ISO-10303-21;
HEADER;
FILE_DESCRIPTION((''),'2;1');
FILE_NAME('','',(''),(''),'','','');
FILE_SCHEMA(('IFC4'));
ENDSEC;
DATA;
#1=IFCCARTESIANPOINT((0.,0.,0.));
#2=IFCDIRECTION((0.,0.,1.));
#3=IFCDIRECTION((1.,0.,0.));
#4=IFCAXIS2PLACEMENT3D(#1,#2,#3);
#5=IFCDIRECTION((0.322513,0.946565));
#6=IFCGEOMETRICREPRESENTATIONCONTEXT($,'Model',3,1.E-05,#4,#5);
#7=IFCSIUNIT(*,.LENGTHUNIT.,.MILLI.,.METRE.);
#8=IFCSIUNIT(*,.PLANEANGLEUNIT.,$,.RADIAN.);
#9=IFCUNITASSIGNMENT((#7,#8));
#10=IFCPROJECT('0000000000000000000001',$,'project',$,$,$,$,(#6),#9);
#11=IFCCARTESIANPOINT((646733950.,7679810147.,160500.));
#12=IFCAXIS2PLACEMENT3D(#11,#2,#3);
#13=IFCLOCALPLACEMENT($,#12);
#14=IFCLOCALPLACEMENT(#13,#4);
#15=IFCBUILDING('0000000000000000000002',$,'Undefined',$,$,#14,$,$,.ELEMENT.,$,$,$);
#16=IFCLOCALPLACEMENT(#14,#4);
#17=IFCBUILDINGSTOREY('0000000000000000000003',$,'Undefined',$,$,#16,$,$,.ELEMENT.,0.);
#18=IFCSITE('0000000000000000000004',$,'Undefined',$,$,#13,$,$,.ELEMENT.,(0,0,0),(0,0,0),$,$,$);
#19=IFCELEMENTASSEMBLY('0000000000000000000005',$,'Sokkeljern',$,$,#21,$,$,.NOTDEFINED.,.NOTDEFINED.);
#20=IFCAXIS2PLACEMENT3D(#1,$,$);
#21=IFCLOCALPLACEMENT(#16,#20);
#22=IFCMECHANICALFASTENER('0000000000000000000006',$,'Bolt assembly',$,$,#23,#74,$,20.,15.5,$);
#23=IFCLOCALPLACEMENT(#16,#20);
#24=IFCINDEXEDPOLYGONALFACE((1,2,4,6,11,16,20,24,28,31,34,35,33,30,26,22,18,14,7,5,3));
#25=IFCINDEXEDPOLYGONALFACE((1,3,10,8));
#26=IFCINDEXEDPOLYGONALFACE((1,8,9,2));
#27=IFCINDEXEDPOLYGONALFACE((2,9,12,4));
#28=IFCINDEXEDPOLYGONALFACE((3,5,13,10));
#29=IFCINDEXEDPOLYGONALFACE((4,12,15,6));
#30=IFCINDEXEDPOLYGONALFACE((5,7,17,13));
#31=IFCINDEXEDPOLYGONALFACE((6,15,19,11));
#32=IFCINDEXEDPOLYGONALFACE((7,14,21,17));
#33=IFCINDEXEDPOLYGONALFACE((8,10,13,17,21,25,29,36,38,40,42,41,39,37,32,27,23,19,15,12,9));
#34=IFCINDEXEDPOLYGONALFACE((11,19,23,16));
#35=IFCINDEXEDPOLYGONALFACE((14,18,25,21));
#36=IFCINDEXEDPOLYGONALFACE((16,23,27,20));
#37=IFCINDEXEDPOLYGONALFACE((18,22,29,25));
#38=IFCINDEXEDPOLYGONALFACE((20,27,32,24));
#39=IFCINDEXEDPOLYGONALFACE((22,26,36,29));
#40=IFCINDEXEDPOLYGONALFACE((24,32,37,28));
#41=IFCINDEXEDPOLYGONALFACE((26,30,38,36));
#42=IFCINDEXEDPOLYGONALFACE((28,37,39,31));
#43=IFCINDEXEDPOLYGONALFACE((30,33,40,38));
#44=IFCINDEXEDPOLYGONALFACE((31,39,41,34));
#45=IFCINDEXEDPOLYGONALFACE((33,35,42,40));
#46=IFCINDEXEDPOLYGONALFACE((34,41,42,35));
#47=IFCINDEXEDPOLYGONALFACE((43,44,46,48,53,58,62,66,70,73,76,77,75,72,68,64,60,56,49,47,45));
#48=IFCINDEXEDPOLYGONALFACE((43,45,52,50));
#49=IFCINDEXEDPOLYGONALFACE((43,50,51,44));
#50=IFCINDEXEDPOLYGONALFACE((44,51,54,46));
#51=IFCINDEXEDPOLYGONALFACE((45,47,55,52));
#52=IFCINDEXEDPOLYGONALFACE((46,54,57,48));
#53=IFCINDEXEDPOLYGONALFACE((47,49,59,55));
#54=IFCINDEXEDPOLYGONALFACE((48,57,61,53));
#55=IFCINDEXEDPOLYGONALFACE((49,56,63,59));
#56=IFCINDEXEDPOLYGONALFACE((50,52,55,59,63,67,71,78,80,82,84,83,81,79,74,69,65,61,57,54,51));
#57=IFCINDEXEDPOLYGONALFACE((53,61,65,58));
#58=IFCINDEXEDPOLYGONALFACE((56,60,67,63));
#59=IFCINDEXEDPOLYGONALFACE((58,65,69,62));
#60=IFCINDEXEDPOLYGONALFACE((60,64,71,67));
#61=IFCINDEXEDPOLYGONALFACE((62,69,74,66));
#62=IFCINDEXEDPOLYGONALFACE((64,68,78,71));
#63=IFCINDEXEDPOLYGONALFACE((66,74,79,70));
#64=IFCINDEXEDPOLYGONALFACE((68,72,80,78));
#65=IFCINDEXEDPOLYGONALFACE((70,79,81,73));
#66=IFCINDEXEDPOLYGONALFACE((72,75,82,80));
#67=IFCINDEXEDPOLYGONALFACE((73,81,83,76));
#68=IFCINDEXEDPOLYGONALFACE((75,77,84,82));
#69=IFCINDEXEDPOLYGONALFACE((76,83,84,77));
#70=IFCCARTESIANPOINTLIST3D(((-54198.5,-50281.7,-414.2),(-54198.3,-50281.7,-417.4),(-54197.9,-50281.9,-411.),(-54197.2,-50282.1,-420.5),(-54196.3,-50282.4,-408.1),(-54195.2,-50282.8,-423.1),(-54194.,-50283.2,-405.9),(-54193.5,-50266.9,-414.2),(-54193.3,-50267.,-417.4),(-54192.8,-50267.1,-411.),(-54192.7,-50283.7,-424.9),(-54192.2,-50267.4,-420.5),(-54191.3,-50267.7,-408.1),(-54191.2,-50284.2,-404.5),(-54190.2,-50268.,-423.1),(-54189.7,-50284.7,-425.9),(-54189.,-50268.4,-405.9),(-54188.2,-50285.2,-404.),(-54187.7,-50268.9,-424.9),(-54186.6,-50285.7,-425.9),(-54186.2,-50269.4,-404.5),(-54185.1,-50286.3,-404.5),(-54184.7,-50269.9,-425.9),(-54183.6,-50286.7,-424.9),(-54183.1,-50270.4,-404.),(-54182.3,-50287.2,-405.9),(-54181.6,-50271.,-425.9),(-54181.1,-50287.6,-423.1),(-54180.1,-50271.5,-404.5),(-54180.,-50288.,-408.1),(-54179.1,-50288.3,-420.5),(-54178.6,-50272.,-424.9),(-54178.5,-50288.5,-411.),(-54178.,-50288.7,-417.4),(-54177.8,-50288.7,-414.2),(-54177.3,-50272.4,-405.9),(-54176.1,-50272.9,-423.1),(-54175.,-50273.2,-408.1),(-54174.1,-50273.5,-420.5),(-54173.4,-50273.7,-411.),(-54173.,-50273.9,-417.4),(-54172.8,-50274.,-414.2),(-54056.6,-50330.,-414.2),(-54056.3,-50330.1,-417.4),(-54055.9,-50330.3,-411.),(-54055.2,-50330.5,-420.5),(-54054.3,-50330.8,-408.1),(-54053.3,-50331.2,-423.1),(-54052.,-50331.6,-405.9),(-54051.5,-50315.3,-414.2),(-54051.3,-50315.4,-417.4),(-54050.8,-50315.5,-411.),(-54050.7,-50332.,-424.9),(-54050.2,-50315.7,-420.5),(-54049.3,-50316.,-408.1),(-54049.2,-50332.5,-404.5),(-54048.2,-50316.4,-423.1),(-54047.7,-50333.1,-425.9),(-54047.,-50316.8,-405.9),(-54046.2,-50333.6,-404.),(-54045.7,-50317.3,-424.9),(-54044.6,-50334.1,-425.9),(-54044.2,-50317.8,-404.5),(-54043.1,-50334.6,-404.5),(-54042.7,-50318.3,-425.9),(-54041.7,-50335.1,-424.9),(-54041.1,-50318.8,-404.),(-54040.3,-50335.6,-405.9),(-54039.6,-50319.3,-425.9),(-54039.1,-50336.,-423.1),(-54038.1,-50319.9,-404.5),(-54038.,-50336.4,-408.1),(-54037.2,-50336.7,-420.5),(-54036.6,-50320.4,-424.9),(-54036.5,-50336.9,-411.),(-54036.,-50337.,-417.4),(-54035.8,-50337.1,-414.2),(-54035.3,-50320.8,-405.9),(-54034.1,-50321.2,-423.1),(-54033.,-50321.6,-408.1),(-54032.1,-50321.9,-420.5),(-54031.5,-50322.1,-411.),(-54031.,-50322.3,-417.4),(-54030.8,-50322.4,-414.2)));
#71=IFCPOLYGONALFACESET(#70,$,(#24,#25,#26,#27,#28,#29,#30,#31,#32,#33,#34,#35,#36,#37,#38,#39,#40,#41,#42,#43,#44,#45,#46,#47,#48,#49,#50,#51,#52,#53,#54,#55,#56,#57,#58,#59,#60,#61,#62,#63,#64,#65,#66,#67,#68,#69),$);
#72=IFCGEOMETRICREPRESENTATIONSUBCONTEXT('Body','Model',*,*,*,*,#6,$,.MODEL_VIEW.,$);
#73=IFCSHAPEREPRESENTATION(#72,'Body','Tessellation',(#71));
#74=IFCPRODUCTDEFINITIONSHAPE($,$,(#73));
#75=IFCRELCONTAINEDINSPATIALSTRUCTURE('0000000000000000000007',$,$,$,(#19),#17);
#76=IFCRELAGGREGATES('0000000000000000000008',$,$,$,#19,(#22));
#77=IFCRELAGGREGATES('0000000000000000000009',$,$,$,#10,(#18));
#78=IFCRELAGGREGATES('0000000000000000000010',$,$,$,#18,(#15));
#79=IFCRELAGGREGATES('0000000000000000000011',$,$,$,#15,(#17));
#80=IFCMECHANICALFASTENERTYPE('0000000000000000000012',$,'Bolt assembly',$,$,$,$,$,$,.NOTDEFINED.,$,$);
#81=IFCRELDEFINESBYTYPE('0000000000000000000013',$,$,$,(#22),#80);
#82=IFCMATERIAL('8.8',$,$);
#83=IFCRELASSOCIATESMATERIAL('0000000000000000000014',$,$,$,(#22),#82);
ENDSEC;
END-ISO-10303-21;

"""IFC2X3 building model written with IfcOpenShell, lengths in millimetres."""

from ifc_helpers import new_model, si_unit, direction, frame, origin_with_axes, origin_2d_with_axis, place, context, subcontext, project, spatial, circle, extrude, source, transform, mapped, material, type_object, element, aggregate, save


model = new_model("IFC2X3")

# Units and contexts
model_context = context("Model", 3, precision=1e-05, world=origin_with_axes(), true_north=direction((0.322513, 0.946565)))
body_context = subcontext(model_context, "Body", "Model", "MODEL_VIEW")
ifc_project = project(units=[si_unit("LENGTHUNIT", "METRE", prefix="MILLI"), si_unit("PLANEANGLEUNIT", "RADIAN")], contexts=[model_context])

# Site, building, storey
site_placement = place(None, frame((646733950.0, 7679810147.0, 160500.0), z_axis=(0.0, 0.0, 1.0), x_axis=(1.0, 0.0, 0.0)))
site = spatial("IfcSite", under=ifc_project, at=site_placement, Name="Undefined", CompositionType="ELEMENT", RefLatitude=(0, 0, 0), RefLongitude=(0, 0, 0))
building_placement = place(site_placement, origin_with_axes())
building = spatial("IfcBuilding", under=site, at=building_placement, Name="Undefined", CompositionType="ELEMENT")
storey_placement = place(building_placement, origin_with_axes())
storey = spatial("IfcBuildingStorey", under=building, at=storey_placement, Name="Undefined", CompositionType="ELEMENT", Elevation=0.0)

# Element assembly
assembly_1_placement = place(storey_placement, origin_with_axes())
assembly_1 = element("IfcElementAssembly", 1, at=assembly_1_placement, inside=storey, Name="Sokkeljern", AssemblyPlace="NOTDEFINED", PredefinedType="NOTDEFINED")

# Mechanical fastener
ifc_material_1 = material(Name="8.8")
mechanical_fastener_type = type_object("IfcMechanicalFastenerType", Name="Bolt assembly")
shared_shape_1 = source(origin_with_axes(), body_context, "Body", "SweptSolid", [
    extrude(circle(Radius=11.0, at=origin_2d_with_axis()), frame((0.0, 0.0, 0.0), z_axis=(0.0, 1.0, 0.0), x_axis=(1.0, 0.0, 0.0)), (0.0, 0.0, 1.0), 15.6),
])
mechanical_fastener_1_placement = place(assembly_1_placement, frame((-54112.1, -50294.6, -415.0), z_axis=(0.946565, -0.322513, 0.0), x_axis=(0.0, 0.0, 1.0)))
mechanical_fastener_1 = element("IfcMechanicalFastener", 2, at=mechanical_fastener_1_placement, type_object=mechanical_fastener_type, material=ifc_material_1, Name="Bolt assembly", NominalDiameter=20.0, NominalLength=15.5, context=body_context, shape_type="MappedRepresentation", body=[
    mapped(shared_shape_1, transform((0.0, 0.0, -75.0))),
    mapped(shared_shape_1, transform((0.0, 0.0, 75.0))),
])
aggregate(assembly_1, [mechanical_fastener_1])

save(model, "model.ifc")
